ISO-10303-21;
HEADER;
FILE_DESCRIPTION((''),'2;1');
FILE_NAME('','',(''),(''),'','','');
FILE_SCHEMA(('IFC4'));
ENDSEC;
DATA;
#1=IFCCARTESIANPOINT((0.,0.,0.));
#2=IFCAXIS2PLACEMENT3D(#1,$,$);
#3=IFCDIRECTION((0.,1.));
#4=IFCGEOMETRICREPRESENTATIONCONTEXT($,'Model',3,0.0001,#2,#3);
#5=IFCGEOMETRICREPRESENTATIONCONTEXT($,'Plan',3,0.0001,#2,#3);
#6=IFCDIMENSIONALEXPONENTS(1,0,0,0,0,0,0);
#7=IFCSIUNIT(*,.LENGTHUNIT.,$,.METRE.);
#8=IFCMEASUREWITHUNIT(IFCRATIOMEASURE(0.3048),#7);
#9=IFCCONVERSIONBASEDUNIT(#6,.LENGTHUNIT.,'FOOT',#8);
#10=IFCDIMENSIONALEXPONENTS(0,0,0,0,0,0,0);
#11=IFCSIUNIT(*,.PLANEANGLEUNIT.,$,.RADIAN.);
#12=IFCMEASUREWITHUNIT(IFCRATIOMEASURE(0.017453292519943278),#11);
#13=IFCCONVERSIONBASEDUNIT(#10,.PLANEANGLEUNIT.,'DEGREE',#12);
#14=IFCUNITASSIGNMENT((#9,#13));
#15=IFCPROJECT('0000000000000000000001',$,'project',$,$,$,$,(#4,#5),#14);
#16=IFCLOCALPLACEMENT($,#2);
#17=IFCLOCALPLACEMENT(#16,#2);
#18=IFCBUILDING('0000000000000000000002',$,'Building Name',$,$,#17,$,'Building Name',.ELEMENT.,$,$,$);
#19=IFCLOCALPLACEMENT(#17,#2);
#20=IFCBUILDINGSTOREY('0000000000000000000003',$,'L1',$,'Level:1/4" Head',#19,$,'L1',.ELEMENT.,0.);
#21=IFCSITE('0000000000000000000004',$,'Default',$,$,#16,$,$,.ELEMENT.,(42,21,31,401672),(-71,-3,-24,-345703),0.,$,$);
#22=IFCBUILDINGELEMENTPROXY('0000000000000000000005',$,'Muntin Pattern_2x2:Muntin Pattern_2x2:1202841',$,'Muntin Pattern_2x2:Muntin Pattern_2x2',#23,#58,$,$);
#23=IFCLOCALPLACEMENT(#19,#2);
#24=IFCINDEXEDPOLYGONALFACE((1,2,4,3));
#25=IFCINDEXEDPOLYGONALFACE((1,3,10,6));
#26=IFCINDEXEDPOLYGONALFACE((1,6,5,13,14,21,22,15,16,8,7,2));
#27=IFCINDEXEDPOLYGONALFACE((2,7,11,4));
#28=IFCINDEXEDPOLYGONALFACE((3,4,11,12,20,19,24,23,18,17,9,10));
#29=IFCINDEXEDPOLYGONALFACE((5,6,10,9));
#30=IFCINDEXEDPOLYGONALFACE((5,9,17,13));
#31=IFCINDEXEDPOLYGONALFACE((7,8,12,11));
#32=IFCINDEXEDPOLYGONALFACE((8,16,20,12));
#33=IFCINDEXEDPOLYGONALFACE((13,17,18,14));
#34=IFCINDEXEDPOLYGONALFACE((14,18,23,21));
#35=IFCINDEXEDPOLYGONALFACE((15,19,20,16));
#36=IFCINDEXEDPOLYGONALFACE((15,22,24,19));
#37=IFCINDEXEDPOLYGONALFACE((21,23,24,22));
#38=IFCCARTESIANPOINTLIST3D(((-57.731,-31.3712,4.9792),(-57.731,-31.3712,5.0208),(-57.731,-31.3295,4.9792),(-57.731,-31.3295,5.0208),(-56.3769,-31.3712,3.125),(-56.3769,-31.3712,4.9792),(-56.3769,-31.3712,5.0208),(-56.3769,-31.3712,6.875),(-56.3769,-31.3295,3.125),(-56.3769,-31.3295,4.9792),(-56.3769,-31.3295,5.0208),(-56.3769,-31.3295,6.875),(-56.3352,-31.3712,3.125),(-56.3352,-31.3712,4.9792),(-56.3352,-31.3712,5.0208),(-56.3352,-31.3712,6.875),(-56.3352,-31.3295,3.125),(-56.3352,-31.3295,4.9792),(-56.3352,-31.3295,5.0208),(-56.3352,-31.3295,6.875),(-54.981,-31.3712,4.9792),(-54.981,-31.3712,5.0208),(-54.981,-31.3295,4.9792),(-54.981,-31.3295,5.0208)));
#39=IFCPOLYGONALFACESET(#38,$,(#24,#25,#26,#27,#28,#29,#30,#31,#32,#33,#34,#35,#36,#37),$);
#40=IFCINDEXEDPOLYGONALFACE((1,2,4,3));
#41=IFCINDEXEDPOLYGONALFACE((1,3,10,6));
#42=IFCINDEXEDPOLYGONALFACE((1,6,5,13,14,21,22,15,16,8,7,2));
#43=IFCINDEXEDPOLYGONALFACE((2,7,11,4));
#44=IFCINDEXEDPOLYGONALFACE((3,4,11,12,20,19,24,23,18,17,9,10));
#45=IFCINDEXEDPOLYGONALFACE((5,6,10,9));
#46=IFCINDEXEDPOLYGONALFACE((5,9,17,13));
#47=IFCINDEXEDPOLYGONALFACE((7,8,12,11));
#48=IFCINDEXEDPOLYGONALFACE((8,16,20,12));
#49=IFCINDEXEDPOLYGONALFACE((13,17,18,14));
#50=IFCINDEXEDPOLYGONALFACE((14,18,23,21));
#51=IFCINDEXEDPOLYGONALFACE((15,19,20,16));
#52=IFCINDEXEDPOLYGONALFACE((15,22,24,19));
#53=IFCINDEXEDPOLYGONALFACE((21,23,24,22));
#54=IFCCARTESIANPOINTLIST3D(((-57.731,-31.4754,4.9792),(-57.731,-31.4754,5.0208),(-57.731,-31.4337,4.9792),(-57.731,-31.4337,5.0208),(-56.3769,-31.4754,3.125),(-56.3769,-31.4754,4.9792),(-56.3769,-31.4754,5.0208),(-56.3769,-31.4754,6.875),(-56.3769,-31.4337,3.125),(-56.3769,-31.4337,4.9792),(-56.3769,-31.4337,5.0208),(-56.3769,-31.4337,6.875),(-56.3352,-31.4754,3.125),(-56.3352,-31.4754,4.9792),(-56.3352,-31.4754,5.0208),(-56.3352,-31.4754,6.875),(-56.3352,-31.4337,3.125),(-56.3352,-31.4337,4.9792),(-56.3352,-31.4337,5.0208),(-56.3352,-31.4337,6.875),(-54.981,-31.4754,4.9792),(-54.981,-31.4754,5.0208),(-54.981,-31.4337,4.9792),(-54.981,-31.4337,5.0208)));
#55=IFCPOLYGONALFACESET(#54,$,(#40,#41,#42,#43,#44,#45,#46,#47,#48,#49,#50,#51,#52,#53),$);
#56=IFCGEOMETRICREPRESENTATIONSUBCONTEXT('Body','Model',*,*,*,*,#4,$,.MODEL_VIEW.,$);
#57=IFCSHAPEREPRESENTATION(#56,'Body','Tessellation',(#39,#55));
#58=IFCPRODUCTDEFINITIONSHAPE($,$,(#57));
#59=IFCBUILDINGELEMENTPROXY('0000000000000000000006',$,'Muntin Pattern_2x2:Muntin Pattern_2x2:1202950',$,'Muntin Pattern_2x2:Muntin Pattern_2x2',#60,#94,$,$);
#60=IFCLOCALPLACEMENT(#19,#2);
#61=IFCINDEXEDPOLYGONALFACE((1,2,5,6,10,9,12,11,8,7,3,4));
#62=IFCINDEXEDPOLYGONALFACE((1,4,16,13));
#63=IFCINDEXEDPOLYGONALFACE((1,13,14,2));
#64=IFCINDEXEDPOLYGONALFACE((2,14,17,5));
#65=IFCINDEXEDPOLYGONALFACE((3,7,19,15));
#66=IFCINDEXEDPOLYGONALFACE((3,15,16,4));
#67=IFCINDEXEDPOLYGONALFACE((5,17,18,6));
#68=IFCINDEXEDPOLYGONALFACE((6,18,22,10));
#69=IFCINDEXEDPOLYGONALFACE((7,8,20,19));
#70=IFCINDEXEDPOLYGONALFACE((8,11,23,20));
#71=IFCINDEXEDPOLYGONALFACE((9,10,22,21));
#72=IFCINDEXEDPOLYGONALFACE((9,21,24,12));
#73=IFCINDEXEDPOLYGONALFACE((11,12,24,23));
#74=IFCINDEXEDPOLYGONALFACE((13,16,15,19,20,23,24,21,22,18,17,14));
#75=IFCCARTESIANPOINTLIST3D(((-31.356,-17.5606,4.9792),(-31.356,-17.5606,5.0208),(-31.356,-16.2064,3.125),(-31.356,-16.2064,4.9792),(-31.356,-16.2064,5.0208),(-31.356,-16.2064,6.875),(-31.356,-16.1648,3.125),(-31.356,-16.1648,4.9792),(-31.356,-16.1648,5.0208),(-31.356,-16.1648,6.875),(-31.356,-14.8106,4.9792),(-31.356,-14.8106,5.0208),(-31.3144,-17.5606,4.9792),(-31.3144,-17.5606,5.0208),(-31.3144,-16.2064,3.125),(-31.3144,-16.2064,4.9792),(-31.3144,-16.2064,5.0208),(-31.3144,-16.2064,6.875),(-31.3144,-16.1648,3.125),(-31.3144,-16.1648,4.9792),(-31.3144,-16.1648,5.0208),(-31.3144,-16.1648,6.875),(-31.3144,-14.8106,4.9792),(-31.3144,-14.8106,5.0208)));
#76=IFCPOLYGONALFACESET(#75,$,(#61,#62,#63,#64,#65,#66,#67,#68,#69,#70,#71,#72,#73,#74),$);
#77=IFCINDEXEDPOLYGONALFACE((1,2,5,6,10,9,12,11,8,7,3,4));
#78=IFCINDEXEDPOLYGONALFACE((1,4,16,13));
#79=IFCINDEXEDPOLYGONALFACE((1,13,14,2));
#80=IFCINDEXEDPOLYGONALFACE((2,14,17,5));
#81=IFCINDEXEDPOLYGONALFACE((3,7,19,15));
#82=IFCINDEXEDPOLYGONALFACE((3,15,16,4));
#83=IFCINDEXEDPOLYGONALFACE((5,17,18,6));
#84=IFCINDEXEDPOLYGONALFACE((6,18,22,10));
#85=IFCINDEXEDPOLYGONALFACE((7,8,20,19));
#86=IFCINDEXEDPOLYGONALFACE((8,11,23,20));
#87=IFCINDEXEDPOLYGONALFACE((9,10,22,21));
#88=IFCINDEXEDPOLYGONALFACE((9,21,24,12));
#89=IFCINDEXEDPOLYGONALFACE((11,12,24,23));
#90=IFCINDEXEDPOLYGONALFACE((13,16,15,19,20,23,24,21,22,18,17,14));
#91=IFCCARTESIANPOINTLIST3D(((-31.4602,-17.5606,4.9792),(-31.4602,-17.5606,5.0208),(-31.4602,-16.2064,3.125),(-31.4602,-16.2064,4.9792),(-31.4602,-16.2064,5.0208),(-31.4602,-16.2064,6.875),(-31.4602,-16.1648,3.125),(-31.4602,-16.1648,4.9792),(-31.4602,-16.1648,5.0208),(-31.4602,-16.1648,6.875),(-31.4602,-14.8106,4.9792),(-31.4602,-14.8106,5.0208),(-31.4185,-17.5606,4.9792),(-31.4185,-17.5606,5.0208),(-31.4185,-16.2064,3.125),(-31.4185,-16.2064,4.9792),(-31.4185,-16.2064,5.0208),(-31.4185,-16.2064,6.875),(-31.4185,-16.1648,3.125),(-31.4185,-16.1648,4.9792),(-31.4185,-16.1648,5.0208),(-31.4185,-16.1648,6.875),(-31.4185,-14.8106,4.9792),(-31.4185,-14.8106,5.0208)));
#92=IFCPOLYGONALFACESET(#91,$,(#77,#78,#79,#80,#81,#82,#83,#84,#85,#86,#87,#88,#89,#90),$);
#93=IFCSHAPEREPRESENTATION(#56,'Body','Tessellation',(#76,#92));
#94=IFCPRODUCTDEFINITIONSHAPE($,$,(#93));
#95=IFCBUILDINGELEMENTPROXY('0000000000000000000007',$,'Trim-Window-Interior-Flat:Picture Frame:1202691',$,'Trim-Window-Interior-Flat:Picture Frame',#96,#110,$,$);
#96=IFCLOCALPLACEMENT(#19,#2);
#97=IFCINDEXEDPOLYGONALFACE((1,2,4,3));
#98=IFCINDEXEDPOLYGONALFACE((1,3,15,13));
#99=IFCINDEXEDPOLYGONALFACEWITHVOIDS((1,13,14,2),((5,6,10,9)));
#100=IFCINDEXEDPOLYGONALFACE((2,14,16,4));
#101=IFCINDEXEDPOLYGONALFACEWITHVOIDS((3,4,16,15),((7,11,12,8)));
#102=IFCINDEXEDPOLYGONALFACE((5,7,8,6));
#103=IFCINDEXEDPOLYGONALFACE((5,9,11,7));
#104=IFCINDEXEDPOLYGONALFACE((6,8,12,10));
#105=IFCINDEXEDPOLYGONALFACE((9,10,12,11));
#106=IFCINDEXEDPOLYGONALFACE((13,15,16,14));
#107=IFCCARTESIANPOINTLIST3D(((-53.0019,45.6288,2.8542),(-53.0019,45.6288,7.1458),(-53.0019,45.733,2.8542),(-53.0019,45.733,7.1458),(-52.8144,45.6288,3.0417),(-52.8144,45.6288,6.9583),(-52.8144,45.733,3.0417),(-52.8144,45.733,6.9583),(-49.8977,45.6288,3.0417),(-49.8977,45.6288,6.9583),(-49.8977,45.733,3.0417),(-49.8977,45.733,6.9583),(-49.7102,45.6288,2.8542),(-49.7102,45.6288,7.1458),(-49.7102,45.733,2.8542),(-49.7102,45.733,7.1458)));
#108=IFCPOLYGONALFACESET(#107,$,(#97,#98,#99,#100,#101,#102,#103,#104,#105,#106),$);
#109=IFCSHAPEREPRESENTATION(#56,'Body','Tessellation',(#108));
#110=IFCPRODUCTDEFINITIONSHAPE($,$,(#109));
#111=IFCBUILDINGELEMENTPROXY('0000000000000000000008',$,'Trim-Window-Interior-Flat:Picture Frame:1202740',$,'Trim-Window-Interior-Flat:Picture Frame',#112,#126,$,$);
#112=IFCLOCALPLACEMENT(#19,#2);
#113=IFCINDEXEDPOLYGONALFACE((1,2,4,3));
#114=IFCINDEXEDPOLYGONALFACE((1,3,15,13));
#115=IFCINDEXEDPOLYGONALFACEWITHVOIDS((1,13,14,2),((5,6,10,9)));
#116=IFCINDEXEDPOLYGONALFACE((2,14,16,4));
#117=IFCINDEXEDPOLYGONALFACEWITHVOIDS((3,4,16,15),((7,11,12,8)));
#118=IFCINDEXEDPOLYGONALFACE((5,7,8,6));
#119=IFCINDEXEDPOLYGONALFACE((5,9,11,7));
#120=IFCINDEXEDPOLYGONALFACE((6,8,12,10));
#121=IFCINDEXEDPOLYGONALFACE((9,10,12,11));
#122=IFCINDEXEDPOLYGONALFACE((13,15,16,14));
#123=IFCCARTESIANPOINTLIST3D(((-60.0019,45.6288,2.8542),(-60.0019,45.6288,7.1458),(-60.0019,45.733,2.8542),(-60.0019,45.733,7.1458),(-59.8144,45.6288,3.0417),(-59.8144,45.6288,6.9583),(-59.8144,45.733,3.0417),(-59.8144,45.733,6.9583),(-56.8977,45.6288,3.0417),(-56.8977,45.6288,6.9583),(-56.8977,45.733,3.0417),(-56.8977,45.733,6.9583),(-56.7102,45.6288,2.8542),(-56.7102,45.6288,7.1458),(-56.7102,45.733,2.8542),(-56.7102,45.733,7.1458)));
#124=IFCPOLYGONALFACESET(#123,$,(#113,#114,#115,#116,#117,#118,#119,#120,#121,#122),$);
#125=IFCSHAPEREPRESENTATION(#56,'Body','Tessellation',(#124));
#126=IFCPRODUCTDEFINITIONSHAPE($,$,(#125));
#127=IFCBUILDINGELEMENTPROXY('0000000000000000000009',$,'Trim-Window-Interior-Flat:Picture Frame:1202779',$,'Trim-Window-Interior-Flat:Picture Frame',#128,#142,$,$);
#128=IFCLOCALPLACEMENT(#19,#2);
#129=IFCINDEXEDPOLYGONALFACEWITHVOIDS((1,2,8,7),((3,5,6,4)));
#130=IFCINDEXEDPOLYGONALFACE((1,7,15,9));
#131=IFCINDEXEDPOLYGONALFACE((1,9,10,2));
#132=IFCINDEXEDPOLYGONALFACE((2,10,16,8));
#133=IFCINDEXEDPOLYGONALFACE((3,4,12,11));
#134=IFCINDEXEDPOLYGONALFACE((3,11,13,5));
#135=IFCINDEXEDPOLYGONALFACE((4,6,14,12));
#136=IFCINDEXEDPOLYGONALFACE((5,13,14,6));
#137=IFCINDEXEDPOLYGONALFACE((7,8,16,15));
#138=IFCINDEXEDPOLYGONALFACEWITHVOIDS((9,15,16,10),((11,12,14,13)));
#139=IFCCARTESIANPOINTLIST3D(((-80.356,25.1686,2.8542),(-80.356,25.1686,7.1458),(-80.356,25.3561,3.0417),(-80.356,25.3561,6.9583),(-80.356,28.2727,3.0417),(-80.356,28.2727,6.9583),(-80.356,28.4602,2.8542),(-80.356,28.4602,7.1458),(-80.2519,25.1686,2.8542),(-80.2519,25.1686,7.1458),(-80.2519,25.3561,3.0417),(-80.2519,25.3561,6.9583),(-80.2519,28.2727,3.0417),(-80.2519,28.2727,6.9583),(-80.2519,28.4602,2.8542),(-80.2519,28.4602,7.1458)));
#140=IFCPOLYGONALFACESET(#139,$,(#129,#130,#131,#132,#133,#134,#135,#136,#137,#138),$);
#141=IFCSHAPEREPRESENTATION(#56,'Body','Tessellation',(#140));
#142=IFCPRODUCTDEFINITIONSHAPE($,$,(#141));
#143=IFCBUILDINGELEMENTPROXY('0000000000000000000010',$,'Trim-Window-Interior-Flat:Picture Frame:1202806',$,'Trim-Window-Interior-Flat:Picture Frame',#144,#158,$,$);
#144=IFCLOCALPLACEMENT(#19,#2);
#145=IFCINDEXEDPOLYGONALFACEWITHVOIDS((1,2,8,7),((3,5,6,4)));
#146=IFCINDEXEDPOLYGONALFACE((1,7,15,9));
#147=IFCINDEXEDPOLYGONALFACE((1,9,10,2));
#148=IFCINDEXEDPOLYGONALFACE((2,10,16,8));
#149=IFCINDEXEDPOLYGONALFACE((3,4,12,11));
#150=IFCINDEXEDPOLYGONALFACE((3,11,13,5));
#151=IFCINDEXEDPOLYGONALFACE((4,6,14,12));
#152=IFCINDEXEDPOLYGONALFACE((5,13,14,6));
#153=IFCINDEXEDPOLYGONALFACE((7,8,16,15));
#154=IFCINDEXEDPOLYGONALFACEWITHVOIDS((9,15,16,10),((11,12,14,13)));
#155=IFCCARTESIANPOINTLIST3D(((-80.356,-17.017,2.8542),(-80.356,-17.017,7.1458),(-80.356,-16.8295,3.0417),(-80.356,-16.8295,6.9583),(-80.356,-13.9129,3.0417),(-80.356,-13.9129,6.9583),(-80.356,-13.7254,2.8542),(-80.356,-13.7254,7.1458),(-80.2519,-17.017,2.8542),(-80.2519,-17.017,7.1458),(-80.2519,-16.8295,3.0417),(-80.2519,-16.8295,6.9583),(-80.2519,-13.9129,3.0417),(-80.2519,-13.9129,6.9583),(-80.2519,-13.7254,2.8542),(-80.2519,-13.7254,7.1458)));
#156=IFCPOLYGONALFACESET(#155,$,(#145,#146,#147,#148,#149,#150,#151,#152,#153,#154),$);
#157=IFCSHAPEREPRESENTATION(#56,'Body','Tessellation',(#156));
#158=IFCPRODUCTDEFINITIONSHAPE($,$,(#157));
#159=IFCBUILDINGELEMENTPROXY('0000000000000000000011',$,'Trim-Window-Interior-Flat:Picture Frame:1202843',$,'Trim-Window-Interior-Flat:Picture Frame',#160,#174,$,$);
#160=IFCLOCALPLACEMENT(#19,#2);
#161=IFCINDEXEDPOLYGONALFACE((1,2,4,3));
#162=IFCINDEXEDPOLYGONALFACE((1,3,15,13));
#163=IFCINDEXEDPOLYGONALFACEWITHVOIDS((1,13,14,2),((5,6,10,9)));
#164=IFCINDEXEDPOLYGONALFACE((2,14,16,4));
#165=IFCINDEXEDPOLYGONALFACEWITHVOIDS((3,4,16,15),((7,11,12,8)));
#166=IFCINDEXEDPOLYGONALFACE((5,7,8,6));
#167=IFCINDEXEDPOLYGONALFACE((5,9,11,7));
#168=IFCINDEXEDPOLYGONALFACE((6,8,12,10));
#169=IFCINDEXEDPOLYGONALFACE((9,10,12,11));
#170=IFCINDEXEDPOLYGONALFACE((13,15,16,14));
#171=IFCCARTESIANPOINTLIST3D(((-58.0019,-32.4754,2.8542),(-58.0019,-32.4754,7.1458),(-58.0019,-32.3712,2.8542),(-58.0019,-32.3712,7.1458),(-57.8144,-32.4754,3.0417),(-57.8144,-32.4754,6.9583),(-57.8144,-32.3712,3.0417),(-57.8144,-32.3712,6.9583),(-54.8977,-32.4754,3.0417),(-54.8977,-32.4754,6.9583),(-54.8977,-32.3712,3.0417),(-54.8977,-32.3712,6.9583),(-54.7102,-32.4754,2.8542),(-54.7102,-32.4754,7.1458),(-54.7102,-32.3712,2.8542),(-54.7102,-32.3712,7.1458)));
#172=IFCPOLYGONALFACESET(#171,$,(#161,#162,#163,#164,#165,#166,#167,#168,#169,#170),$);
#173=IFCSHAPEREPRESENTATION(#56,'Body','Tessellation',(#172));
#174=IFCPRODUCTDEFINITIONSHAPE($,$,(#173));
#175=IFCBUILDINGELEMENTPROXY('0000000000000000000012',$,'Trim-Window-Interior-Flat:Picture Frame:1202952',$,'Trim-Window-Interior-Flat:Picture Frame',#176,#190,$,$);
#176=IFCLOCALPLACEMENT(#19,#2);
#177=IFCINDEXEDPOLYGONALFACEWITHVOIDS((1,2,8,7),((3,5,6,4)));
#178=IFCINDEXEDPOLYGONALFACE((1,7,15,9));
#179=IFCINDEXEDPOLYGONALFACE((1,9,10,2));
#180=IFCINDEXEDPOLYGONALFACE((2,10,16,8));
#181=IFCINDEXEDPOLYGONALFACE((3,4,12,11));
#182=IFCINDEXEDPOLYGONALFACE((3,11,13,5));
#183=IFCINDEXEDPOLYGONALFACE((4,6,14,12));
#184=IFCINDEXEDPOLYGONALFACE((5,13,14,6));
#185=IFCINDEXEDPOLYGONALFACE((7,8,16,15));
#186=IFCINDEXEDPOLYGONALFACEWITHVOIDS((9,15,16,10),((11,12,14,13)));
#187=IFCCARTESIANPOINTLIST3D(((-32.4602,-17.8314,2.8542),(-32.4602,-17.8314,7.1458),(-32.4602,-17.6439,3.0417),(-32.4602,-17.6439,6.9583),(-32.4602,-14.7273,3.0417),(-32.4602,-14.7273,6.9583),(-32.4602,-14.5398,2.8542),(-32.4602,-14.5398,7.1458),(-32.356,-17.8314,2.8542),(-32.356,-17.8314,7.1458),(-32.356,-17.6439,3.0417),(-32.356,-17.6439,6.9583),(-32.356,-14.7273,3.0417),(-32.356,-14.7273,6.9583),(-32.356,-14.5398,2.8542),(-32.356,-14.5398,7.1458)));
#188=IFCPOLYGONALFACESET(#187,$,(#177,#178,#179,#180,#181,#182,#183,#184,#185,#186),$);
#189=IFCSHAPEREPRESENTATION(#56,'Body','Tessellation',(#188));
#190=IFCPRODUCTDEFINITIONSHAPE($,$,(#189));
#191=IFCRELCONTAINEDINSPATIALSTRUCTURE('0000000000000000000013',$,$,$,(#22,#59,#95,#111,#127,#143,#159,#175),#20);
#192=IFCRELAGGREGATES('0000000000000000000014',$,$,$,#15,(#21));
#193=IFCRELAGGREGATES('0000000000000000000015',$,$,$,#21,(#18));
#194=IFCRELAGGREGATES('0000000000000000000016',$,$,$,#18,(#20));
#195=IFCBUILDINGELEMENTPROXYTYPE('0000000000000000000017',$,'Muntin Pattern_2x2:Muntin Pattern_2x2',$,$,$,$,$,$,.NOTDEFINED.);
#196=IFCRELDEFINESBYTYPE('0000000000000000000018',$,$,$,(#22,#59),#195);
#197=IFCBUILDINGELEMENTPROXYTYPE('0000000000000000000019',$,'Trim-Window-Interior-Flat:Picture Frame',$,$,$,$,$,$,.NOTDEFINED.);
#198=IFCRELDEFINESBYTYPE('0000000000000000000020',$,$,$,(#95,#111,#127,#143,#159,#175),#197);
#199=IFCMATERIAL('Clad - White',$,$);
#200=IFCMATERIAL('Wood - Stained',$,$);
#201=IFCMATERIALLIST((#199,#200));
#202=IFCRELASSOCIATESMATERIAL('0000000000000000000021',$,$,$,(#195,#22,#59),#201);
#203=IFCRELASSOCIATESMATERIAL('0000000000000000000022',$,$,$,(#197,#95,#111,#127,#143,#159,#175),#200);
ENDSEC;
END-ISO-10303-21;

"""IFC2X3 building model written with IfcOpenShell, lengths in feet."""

from ifc_helpers import new_model, entity, si_unit, converted_unit, direction, frame, origin, place, context, subcontext, project, spatial, polyline, outline, extrude, source, transform, mapped, material, material_list, type_object, type_shapes, element, save


model = new_model("IFC2X3")

# Units and contexts
model_context = context("Model", 3, precision=0.0001, world=origin(), true_north=direction((0.0, 1.0)))
plan_context = context("Plan", 3, precision=0.0001, world=origin(), true_north=direction((0.0, 1.0)))
body_context = subcontext(model_context, "Body", "Model", "MODEL_VIEW")
ifc_project = project(units=[converted_unit("LENGTHUNIT", "FOOT", entity("IfcRatioMeasure", 0.3048), si_unit("LENGTHUNIT", "METRE"), dimensions=[1, 0, 0, 0, 0, 0, 0]), converted_unit("PLANEANGLEUNIT", "DEGREE", entity("IfcRatioMeasure", 0.017453292519943278), si_unit("PLANEANGLEUNIT", "RADIAN"), dimensions=[0, 0, 0, 0, 0, 0, 0])], contexts=[model_context, plan_context])

# Site, building, storey
site_placement = place(None, origin())
site = spatial("IfcSite", under=ifc_project, at=site_placement, Name="Default", CompositionType="ELEMENT", RefLatitude=(42, 21, 31, 401672), RefLongitude=(-71, -3, -24, -345703), RefElevation=0.0)
building_placement = place(site_placement, origin())
building = spatial("IfcBuilding", under=site, at=building_placement, Name="Building Name", LongName="Building Name", CompositionType="ELEMENT")
storey_placement = place(building_placement, origin())
storey = spatial("IfcBuildingStorey", under=building, at=storey_placement, Name="L1", ObjectType="Level:1/4\" Head", LongName="L1", CompositionType="ELEMENT", Elevation=0.0)

# Building element proxies
ifc_material_1 = material(Name="Clad - White")
ifc_material_2 = material(Name="Wood - Stained")
ifc_material_list = material_list([ifc_material_1, ifc_material_2])
building_element_proxy_type_1 = type_object("IfcBuildingElementProxyType", Name="Muntin Pattern_2x2:Muntin Pattern_2x2", PredefinedType="NOTDEFINED", material=ifc_material_list)
shared_shape_1 = source(origin(), body_context, "Body", "SweptSolid", [
    extrude(outline(polyline([(0.0208, -0.0208), (1.875, -0.0208), (1.875, 0.0208), (0.0208, 0.0208), (0.0208, 1.375), (-0.0208, 1.375), (-0.0208, 0.0208), (-1.875, 0.0208), (-1.875, -0.0208), (-0.0208, -0.0208), (-0.0208, -1.375), (0.0208, -1.375), (0.0208, -0.0208)])), frame((0.0, -0.0729, 1.875), z_axis=(0.0, 1.0, 0.0), x_axis=(0.0, 0.0, 1.0)), (0.0, 0.0, 1.0), 0.0417),
    extrude(outline(polyline([(0.0208, -0.0208), (1.875, -0.0208), (1.875, 0.0208), (0.0208, 0.0208), (0.0208, 1.375), (-0.0208, 1.375), (-0.0208, 0.0208), (-1.875, 0.0208), (-1.875, -0.0208), (-0.0208, -0.0208), (-0.0208, -1.375), (0.0208, -1.375), (0.0208, -0.0208)])), frame((0.0, 0.0313, 1.875), z_axis=(0.0, 1.0, 0.0), x_axis=(0.0, 0.0, 1.0)), (0.0, 0.0, 1.0), 0.0417),
])
type_shapes(building_element_proxy_type_1, [shared_shape_1])
for number, where, z_axis, x_axis, name in (
    (1, (-56.356, -31.4025, 3.125), (0.0, 0.0, 1.0), (-1.0, 0.0, 0.0), "Muntin Pattern_2x2:Muntin Pattern_2x2:1202841"),
    (2, (-31.3873, -16.1856, 3.125), (0.0, 0.0, 1.0), (0.0, 1.0, 0.0), "Muntin Pattern_2x2:Muntin Pattern_2x2:1202950"),
):
    element("IfcBuildingElementProxy", number, at=place(storey_placement, frame(where, z_axis=z_axis, x_axis=x_axis)), inside=storey, type_object=building_element_proxy_type_1, material=ifc_material_list, Name=name, ObjectType="Muntin Pattern_2x2:Muntin Pattern_2x2", context=body_context, shape_type="MappedRepresentation", body=[
        mapped(shared_shape_1, transform((0.0, 0.0, 0.0), scale=1.0)),
    ])
building_element_proxy_type_2 = type_object("IfcBuildingElementProxyType", Name="Trim-Window-Interior-Flat:Picture Frame", PredefinedType="NOTDEFINED", material=ifc_material_2)
shared_shape_2 = source(origin(), body_context, "Body", "SweptSolid", [
    extrude(outline(polyline([(-1.6458, -2.1458), (1.6458, -2.1458), (1.6458, 2.1458), (-1.6458, 2.1458), (-1.6458, -2.1458)]), holes=[polyline([(-1.4583, -1.9583), (-1.4583, 1.9583), (1.4583, 1.9583), (1.4583, -1.9583), (-1.4583, -1.9583)])]), frame((0.0, -2.0, 0.0), z_axis=(0.0, 0.0, 1.0), x_axis=(-1.0, 0.0, 0.0)), (0.0, 0.0, 1.0), 0.1042),
])
type_shapes(building_element_proxy_type_2, [shared_shape_2])
for number, where, z_axis, x_axis, name in (
    (3, (-51.356, 45.6288, 7.0), (0.0, 1.0, 0.0), (-1.0, 0.0, 0.0), "Trim-Window-Interior-Flat:Picture Frame:1202691"),
    (4, (-58.356, 45.6288, 7.0), (0.0, 1.0, 0.0), (-1.0, 0.0, 0.0), "Trim-Window-Interior-Flat:Picture Frame:1202740"),
    (5, (-80.356, 26.8144, 7.0), (1.0, 0.0, 0.0), (0.0, 1.0, 0.0), "Trim-Window-Interior-Flat:Picture Frame:1202779"),
    (6, (-80.356, -15.3712, 7.0), (1.0, 0.0, 0.0), (0.0, 1.0, 0.0), "Trim-Window-Interior-Flat:Picture Frame:1202806"),
    (7, (-56.356, -32.3712, 7.0), (0.0, -1.0, 0.0), (1.0, 0.0, 0.0), "Trim-Window-Interior-Flat:Picture Frame:1202843"),
    (8, (-32.356, -16.1856, 7.0), (-1.0, 0.0, 0.0), (0.0, -1.0, 0.0), "Trim-Window-Interior-Flat:Picture Frame:1202952"),
):
    element("IfcBuildingElementProxy", number, at=place(storey_placement, frame(where, z_axis=z_axis, x_axis=x_axis)), inside=storey, type_object=building_element_proxy_type_2, material=ifc_material_2, Name=name, ObjectType="Trim-Window-Interior-Flat:Picture Frame", context=body_context, shape_type="MappedRepresentation", body=[
        mapped(shared_shape_2, transform((0.0, 0.0, 0.0), scale=1.0)),
    ])

save(model, "model.ifc")
